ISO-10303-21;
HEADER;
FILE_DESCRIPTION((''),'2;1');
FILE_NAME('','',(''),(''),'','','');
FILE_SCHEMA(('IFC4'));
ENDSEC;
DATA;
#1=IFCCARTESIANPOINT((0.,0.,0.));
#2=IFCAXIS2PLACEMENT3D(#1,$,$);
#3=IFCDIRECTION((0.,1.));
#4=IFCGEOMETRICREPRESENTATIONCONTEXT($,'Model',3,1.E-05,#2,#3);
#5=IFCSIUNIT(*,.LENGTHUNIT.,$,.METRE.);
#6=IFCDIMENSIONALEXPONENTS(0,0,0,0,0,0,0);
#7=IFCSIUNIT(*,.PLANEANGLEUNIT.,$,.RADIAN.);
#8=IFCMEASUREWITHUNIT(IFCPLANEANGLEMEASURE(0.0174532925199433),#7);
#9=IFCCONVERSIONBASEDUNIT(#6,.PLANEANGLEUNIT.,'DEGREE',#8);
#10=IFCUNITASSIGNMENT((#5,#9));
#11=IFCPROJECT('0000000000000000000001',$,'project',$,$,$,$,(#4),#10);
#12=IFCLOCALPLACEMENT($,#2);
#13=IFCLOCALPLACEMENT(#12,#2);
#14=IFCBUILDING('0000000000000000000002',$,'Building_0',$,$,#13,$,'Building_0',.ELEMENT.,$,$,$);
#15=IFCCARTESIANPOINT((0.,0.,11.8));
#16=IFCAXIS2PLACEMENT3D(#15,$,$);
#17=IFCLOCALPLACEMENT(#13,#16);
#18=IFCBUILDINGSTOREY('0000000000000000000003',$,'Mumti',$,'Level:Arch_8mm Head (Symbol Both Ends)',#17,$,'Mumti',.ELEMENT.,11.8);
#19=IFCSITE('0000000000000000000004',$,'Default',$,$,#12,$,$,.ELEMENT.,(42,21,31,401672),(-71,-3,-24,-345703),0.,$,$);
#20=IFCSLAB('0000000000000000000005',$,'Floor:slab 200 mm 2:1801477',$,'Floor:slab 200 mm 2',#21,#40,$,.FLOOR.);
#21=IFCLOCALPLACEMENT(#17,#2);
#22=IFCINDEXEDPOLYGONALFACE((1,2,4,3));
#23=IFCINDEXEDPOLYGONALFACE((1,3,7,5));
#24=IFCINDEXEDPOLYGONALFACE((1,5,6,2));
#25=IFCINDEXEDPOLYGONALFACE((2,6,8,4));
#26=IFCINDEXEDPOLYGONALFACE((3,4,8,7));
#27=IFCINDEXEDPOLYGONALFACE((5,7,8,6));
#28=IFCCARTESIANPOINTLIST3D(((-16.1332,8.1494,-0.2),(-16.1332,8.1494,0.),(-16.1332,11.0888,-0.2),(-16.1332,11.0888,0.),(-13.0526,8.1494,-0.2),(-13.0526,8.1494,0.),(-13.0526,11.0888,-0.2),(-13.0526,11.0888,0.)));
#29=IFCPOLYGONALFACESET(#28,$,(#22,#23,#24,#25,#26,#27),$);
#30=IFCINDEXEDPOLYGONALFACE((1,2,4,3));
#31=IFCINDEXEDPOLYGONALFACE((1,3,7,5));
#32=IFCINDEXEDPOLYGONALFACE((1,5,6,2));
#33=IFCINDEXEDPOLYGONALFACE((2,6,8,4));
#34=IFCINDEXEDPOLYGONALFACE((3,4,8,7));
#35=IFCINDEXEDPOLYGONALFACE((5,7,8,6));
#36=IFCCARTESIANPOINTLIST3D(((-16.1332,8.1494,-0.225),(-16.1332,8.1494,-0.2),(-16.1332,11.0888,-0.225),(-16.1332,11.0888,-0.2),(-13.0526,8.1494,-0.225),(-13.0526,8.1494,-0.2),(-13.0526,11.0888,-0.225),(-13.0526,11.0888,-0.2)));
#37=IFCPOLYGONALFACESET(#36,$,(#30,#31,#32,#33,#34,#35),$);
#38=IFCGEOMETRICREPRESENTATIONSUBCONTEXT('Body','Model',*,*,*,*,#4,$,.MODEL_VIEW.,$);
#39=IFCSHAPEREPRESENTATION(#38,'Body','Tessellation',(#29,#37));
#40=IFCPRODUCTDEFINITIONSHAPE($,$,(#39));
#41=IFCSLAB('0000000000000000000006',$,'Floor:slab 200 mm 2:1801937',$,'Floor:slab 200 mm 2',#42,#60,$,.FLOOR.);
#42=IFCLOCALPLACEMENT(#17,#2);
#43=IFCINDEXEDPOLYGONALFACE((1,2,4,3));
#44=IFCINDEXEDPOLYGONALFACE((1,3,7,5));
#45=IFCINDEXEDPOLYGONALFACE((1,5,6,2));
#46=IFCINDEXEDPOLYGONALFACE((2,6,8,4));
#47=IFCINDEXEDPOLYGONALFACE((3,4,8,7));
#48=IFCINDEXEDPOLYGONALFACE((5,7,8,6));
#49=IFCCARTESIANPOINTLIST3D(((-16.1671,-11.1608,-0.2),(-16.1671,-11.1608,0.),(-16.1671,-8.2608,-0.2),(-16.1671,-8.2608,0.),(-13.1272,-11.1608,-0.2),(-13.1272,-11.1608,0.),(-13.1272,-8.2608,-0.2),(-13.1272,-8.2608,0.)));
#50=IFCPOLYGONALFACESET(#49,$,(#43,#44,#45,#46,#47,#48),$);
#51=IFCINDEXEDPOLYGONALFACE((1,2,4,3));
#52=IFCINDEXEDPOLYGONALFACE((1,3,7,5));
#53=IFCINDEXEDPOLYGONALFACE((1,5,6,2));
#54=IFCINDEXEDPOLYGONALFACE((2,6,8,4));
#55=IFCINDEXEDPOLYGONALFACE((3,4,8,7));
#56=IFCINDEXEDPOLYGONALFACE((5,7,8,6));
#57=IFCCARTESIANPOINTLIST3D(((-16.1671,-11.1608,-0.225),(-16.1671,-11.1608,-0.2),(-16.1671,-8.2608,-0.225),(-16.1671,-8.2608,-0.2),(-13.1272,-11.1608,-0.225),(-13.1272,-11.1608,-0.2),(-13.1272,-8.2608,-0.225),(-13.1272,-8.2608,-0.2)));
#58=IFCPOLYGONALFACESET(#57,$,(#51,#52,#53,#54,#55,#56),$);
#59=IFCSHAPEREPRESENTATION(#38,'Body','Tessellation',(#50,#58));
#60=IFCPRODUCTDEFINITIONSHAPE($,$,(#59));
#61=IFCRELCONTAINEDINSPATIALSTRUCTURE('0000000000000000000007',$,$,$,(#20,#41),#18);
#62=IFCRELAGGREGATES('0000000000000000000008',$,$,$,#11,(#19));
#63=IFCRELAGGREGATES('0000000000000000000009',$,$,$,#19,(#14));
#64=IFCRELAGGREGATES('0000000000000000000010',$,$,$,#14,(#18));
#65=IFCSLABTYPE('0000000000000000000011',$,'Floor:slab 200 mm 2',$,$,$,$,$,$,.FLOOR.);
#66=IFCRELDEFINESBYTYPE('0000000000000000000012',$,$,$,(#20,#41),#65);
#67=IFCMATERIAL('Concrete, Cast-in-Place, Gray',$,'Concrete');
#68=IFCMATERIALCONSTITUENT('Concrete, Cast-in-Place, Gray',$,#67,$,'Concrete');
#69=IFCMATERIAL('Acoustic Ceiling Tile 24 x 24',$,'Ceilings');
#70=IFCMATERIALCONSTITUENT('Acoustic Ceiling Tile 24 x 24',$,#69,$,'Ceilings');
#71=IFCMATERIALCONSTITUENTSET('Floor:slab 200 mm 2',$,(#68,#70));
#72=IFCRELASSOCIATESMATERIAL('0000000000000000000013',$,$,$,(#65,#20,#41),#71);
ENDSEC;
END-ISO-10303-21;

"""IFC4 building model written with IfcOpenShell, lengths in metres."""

from ifc_helpers import new_model, entity, si_unit, converted_unit, direction, frame, origin, place, context, subcontext, project, spatial, indexed_curve, outline, extrude, material, constituent, constituent_set, type_object, element, save


model = new_model("IFC4")

# Units and contexts
model_context = context("Model", 3, precision=1e-05, world=origin(), true_north=direction((0.0, 1.0)))
body_context = subcontext(model_context, "Body", "Model", "MODEL_VIEW")
ifc_project = project(units=[si_unit("LENGTHUNIT", "METRE"), converted_unit("PLANEANGLEUNIT", "DEGREE", entity("IfcPlaneAngleMeasure", 0.0174532925199433), si_unit("PLANEANGLEUNIT", "RADIAN"), dimensions=[0, 0, 0, 0, 0, 0, 0])], contexts=[model_context])

# Site, building, storey
site_placement = place(None, origin())
site = spatial("IfcSite", under=ifc_project, at=site_placement, Name="Default", CompositionType="ELEMENT", RefLatitude=(42, 21, 31, 401672), RefLongitude=(-71, -3, -24, -345703), RefElevation=0.0)
building_placement = place(site_placement, origin())
building = spatial("IfcBuilding", under=site, at=building_placement, Name="Building_0", LongName="Building_0", CompositionType="ELEMENT")
storey_placement = place(building_placement, frame((0.0, 0.0, 11.8)))
storey = spatial("IfcBuildingStorey", under=building, at=storey_placement, Name="Mumti", ObjectType="Level:Arch_8mm Head (Symbol Both Ends)", LongName="Mumti", CompositionType="ELEMENT", Elevation=11.8)

# Slabs
ifc_material_1 = material(Name="Concrete, Cast-in-Place, Gray", Category="Concrete")
ifc_constituent_1 = constituent(ifc_material_1, Name="Concrete, Cast-in-Place, Gray", Category="Concrete")
ifc_material_2 = material(Name="Acoustic Ceiling Tile 24 x 24", Category="Ceilings")
ifc_constituent_2 = constituent(ifc_material_2, Name="Acoustic Ceiling Tile 24 x 24", Category="Ceilings")
ifc_constituent_set = constituent_set(constituents=[ifc_constituent_1, ifc_constituent_2], Name="Floor:slab 200 mm 2")
slab_type = type_object("IfcSlabType", Name="Floor:slab 200 mm 2", PredefinedType="FLOOR", material=ifc_constituent_set)
slab_1_placement = place(storey_placement, origin())
element("IfcSlab", 1, at=slab_1_placement, inside=storey, type_object=slab_type, material=ifc_constituent_set, Name="Floor:slab 200 mm 2:1801477", ObjectType="Floor:slab 200 mm 2", PredefinedType="FLOOR", context=body_context, shape_type="SweptSolid", body=[
    extrude(outline(indexed_curve([(-1.5403, -1.4697), (1.5403, -1.4697), (1.5403, 1.4697), (-1.5403, 1.4697), (-1.5403, -1.4697)], self_intersect=False)), frame((-14.5929, 9.6191, -0.2), z_axis=(0.0, 0.0, 1.0), x_axis=(-1.0, 0.0, 0.0)), (0.0, 0.0, 1.0), 0.2),
    extrude(outline(indexed_curve([(-1.5403, -1.4697), (1.5403, -1.4697), (1.5403, 1.4697), (-1.5403, 1.4697), (-1.5403, -1.4697)], self_intersect=False)), frame((-14.5929, 9.6191, -0.225), z_axis=(0.0, 0.0, 1.0), x_axis=(-1.0, 0.0, 0.0)), (0.0, 0.0, 1.0), 0.025),
])
slab_2_placement = place(storey_placement, origin())
element("IfcSlab", 2, at=slab_2_placement, inside=storey, type_object=slab_type, material=ifc_constituent_set, Name="Floor:slab 200 mm 2:1801937", ObjectType="Floor:slab 200 mm 2", PredefinedType="FLOOR", context=body_context, shape_type="SweptSolid", body=[
    extrude(outline(indexed_curve([(-1.52, -1.45), (1.52, -1.45), (1.52, 1.45), (-1.52, 1.45), (-1.52, -1.45)], self_intersect=False)), frame((-14.6472, -9.7108, -0.2), z_axis=(0.0, 0.0, 1.0), x_axis=(-1.0, 0.0, 0.0)), (0.0, 0.0, 1.0), 0.2),
    extrude(outline(indexed_curve([(-1.52, -1.45), (1.52, -1.45), (1.52, 1.45), (-1.52, 1.45), (-1.52, -1.45)], self_intersect=False)), frame((-14.6472, -9.7108, -0.225), z_axis=(0.0, 0.0, 1.0), x_axis=(-1.0, 0.0, 0.0)), (0.0, 0.0, 1.0), 0.025),
])

save(model, "model.ifc")
